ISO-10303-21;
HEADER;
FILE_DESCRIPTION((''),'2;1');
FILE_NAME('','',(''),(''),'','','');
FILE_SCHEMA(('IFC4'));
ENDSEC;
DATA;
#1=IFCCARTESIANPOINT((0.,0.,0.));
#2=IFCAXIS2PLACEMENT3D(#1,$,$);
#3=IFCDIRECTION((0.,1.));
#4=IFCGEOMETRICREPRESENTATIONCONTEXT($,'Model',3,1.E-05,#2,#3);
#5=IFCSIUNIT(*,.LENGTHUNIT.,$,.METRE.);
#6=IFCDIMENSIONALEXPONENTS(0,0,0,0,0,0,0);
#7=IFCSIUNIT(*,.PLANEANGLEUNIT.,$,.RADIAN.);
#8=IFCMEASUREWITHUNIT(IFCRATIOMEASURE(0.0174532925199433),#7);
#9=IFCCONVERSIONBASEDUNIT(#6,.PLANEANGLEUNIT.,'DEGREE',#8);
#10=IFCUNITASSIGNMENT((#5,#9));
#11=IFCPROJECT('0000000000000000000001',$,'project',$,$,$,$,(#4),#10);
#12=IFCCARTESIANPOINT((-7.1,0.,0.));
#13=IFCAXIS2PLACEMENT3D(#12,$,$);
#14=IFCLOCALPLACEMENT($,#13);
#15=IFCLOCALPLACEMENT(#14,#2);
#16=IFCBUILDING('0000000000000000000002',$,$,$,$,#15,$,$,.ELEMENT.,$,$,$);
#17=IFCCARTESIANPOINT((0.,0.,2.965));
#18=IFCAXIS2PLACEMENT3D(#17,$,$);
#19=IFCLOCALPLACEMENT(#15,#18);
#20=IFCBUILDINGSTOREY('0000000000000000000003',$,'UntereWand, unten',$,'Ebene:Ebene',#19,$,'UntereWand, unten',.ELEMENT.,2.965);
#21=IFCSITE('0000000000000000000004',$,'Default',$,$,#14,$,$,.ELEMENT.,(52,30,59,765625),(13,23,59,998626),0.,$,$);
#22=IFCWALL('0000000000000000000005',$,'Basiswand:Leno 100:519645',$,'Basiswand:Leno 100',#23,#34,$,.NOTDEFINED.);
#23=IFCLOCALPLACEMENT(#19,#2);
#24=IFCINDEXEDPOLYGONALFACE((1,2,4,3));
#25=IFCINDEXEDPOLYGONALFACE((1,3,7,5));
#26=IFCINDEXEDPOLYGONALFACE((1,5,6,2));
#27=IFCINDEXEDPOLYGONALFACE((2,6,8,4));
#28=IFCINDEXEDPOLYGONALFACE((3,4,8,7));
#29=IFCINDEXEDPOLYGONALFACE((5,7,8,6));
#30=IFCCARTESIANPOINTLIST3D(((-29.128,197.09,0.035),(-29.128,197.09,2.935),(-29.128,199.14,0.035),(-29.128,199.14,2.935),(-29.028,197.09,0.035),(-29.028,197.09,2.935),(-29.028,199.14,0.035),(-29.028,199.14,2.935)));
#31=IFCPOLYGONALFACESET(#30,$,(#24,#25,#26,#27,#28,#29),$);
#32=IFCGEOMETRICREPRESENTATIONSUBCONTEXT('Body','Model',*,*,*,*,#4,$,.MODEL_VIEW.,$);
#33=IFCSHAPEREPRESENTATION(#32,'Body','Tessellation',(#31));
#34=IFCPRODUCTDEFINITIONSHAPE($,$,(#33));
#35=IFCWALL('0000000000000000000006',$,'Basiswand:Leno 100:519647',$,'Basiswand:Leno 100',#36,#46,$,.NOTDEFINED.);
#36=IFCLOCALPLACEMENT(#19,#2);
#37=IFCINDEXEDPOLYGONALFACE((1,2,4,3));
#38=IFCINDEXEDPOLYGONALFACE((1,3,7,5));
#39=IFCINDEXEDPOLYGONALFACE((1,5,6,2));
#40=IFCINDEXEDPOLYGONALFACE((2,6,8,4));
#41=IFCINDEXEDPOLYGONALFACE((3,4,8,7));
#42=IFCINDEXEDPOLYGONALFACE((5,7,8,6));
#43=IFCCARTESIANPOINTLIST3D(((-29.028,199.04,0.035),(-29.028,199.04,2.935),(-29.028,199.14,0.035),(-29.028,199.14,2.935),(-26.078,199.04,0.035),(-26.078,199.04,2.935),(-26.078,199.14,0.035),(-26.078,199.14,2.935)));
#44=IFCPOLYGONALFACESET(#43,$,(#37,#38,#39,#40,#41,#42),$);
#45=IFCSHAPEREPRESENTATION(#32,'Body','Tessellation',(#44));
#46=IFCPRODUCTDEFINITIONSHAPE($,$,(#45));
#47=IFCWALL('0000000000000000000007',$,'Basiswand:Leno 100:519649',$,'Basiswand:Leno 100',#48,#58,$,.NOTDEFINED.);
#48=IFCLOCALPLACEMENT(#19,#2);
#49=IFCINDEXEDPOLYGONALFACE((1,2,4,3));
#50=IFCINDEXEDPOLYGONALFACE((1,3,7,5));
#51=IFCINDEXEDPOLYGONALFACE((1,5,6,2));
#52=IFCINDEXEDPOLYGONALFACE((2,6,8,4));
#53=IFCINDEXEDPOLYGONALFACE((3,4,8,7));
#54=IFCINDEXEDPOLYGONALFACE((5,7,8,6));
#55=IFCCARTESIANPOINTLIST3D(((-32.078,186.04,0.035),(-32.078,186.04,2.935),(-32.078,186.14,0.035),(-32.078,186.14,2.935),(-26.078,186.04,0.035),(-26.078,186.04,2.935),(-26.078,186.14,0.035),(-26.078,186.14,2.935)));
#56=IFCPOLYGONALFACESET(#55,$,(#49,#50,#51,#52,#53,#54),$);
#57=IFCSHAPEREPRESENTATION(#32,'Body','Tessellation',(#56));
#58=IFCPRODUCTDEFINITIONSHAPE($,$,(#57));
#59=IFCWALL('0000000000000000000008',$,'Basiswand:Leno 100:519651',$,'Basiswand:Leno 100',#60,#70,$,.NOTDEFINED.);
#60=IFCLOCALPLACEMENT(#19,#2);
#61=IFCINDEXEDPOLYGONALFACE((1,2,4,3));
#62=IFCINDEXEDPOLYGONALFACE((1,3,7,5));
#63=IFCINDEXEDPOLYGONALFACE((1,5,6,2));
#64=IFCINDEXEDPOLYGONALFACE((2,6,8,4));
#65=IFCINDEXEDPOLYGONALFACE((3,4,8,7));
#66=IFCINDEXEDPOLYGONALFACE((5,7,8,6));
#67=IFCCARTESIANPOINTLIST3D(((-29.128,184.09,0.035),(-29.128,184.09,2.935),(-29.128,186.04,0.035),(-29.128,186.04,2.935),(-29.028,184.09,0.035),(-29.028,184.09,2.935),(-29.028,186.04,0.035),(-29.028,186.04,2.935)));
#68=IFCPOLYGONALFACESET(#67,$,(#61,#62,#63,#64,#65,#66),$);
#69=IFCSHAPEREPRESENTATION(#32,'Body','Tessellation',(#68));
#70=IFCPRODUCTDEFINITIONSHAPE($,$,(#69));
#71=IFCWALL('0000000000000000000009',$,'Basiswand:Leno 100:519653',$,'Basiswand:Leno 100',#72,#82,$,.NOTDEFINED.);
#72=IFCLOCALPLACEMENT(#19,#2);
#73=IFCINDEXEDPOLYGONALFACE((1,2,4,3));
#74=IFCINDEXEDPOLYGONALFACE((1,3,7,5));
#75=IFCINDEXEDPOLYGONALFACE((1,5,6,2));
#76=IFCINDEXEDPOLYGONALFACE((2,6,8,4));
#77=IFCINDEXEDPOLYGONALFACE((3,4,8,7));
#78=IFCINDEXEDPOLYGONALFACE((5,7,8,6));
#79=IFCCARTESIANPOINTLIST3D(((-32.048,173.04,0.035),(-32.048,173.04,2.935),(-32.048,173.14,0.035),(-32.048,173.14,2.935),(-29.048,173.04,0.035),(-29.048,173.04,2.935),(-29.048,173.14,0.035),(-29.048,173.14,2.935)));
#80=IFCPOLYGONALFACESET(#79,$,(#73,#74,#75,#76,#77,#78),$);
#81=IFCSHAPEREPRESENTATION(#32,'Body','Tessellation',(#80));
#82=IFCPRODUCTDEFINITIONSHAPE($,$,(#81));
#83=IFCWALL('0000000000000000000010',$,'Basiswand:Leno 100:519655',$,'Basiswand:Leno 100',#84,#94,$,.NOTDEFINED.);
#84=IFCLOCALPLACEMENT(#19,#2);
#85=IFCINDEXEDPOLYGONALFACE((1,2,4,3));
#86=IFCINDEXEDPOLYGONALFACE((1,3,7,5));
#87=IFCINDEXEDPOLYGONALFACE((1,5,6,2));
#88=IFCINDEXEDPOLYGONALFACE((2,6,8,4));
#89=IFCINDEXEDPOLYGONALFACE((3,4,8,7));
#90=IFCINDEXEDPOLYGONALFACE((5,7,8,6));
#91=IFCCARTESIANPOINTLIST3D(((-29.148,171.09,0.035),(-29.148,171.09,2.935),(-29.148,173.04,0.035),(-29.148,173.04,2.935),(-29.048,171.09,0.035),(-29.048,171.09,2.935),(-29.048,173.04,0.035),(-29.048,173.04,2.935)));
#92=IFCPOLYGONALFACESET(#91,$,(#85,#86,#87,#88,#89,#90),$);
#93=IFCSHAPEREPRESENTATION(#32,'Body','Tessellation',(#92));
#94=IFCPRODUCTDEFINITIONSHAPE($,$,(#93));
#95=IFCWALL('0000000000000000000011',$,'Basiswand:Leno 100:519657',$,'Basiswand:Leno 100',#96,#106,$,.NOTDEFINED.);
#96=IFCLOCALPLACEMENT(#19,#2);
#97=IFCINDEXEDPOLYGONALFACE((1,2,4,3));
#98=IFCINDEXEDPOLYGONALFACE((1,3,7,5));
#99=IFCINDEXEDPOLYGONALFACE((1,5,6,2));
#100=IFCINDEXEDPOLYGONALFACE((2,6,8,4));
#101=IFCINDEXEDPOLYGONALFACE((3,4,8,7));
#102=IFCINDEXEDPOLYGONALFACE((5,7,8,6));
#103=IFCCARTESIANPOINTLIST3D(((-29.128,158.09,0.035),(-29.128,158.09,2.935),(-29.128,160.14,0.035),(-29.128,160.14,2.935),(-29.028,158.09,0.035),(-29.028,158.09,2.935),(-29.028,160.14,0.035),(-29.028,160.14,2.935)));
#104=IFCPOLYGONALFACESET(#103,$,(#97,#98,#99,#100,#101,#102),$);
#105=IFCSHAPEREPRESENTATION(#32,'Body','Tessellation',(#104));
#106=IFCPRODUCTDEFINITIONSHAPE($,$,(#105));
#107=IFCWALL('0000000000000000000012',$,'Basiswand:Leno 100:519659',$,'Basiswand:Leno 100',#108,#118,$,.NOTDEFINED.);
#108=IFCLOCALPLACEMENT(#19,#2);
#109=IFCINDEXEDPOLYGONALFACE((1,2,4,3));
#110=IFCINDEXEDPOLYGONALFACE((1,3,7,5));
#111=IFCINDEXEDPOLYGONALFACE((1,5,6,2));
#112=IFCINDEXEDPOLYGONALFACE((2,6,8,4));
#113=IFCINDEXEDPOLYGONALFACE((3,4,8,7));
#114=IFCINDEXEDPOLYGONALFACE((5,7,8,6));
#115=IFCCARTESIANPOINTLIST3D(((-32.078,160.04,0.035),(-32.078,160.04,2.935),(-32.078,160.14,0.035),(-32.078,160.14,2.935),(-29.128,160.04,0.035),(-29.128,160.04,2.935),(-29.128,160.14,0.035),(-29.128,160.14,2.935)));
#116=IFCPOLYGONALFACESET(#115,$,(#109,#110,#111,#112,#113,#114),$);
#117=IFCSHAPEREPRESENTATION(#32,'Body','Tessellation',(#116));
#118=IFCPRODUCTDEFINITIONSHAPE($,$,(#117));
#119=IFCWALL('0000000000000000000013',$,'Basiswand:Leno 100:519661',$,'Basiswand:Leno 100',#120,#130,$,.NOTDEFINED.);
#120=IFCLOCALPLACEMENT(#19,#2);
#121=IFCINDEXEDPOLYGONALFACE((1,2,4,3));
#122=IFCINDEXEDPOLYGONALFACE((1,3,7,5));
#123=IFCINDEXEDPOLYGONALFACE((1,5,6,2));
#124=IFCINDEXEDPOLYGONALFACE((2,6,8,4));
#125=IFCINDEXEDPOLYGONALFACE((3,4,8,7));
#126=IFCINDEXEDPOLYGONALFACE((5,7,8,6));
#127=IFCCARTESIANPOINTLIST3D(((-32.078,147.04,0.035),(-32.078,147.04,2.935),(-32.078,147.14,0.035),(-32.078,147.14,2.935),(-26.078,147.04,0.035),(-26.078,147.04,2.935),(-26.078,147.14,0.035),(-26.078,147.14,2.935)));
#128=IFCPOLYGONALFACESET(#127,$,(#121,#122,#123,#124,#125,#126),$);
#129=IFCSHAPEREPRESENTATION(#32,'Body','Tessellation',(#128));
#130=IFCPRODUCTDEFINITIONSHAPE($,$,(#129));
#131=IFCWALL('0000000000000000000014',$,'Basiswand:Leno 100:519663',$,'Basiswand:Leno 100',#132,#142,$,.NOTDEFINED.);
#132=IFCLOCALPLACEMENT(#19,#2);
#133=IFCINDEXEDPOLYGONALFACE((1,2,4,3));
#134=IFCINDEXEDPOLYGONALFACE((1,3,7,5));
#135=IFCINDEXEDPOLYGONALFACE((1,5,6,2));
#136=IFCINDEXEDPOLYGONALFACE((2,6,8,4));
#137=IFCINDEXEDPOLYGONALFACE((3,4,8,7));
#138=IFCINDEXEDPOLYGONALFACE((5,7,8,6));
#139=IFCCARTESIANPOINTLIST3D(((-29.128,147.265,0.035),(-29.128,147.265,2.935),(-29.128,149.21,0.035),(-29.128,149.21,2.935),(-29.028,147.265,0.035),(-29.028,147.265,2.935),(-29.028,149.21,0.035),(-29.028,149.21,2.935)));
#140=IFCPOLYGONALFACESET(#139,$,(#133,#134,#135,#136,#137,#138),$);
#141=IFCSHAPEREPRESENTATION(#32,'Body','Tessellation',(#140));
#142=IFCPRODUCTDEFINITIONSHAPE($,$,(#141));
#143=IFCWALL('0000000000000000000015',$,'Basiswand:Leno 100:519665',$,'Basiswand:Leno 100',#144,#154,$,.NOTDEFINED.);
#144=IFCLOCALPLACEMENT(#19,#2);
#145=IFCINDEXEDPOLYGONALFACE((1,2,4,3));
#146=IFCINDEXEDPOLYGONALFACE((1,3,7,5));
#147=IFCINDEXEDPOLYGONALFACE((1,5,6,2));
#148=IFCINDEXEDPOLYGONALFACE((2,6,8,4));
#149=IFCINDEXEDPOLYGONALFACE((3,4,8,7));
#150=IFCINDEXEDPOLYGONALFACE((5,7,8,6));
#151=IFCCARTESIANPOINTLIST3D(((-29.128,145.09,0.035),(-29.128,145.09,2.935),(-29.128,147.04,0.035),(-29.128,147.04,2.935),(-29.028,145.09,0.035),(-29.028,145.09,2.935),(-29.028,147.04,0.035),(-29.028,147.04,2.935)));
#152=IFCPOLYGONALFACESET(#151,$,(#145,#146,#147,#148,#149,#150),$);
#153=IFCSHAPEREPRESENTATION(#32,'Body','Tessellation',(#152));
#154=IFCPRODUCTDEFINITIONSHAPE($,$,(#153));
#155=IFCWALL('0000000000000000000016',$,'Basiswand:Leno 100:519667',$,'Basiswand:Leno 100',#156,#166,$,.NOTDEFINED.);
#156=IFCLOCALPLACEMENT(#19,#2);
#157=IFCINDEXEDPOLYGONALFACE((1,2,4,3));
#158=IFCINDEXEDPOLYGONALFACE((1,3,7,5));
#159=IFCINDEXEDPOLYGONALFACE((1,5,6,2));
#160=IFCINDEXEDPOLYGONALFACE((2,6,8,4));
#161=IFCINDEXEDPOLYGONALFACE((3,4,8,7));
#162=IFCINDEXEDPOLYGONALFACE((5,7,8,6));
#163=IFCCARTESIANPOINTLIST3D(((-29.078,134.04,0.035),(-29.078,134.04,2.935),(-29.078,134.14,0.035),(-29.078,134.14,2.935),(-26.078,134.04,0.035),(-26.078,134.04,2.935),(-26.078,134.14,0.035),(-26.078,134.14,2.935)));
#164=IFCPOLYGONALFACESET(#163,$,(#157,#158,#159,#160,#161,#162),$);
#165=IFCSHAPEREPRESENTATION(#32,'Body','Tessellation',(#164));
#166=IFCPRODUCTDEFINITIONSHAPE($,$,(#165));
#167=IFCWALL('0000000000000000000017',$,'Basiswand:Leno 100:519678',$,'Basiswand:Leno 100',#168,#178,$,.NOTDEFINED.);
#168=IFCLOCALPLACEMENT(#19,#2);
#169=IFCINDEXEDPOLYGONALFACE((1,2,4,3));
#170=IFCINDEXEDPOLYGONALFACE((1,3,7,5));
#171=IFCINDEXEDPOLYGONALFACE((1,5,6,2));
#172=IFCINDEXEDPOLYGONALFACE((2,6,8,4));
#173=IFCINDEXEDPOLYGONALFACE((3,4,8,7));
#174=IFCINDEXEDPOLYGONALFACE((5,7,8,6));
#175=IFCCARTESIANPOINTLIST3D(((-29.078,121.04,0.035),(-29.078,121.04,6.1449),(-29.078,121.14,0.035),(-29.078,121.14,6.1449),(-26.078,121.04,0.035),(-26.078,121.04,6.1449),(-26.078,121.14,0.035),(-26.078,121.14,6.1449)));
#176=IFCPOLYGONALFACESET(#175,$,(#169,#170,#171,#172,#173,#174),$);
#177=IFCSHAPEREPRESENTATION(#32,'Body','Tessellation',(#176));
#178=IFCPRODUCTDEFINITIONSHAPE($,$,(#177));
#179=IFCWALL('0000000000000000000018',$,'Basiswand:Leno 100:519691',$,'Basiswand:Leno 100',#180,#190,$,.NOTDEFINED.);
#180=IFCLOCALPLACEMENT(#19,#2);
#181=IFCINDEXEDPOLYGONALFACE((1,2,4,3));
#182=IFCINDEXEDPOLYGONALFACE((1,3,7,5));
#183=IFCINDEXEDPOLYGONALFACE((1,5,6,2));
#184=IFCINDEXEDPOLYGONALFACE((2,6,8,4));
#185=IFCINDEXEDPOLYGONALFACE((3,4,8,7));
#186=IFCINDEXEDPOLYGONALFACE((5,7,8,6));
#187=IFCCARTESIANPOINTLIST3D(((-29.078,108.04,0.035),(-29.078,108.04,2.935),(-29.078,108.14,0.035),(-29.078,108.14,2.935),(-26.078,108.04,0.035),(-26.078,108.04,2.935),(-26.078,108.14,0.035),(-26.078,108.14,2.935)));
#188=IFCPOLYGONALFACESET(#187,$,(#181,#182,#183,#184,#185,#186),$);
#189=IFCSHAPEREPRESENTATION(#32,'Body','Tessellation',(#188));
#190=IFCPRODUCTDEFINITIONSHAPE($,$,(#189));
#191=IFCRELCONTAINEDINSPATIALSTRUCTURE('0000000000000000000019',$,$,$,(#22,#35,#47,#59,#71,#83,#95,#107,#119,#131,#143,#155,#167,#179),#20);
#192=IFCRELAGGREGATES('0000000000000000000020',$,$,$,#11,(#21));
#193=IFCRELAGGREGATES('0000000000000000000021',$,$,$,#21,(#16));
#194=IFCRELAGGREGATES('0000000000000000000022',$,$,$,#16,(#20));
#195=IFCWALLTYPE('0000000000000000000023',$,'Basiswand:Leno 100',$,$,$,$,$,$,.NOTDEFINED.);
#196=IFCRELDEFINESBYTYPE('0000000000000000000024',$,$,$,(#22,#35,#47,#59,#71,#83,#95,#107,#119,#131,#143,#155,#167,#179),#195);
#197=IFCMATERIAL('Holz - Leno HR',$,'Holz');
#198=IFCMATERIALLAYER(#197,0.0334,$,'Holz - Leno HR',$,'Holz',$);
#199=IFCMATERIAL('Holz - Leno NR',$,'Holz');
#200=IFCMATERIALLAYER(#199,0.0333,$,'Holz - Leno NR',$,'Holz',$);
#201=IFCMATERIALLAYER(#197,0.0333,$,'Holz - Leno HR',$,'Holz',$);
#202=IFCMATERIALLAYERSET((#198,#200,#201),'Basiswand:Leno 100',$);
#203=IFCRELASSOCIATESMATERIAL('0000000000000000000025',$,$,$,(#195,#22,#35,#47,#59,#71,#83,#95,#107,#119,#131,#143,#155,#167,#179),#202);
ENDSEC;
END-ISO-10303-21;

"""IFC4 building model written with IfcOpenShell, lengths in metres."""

from ifc_helpers import new_model, entity, si_unit, converted_unit, direction, frame, origin, place, context, subcontext, project, spatial, indexed_curve, outline, extrude, material, layer, layer_set, type_object, element, save


model = new_model("IFC4")

# Units and contexts
model_context = context("Model", 3, precision=1e-05, world=origin(), true_north=direction((0.0, 1.0)))
body_context = subcontext(model_context, "Body", "Model", "MODEL_VIEW")
ifc_project = project(units=[si_unit("LENGTHUNIT", "METRE"), converted_unit("PLANEANGLEUNIT", "DEGREE", entity("IfcRatioMeasure", 0.0174532925199433), si_unit("PLANEANGLEUNIT", "RADIAN"), dimensions=[0, 0, 0, 0, 0, 0, 0])], contexts=[model_context])

# Site, building, storey
site_placement = place(None, frame((-7.1, 0.0, 0.0)))
site = spatial("IfcSite", under=ifc_project, at=site_placement, Name="Default", CompositionType="ELEMENT", RefLatitude=(52, 30, 59, 765625), RefLongitude=(13, 23, 59, 998626), RefElevation=0.0)
building_placement = place(site_placement, origin())
building = spatial("IfcBuilding", under=site, at=building_placement, CompositionType="ELEMENT")
storey_placement = place(building_placement, frame((0.0, 0.0, 2.965)))
storey = spatial("IfcBuildingStorey", under=building, at=storey_placement, Name="UntereWand, unten", ObjectType="Ebene:Ebene", LongName="UntereWand, unten", CompositionType="ELEMENT", Elevation=2.965)

# Walls
ifc_material_1 = material(Name="Holz - Leno HR", Category="Holz")
ifc_layer_1 = layer(ifc_material_1, 0.0334, Name="Holz - Leno HR", Category="Holz")
ifc_material_2 = material(Name="Holz - Leno NR", Category="Holz")
ifc_layer_2 = layer(ifc_material_2, 0.0333, Name="Holz - Leno NR", Category="Holz")
ifc_layer_3 = layer(ifc_material_1, 0.0333, Name="Holz - Leno HR", Category="Holz")
ifc_layer_set = layer_set([ifc_layer_1, ifc_layer_2, ifc_layer_3], Name="Basiswand:Leno 100")
wall_type = type_object("IfcWallType", Name="Basiswand:Leno 100", PredefinedType="NOTDEFINED", material=ifc_layer_set)
wall_1_placement = place(storey_placement, frame((-29.078, 197.09, 0.035), z_axis=(0.0, 0.0, 1.0), x_axis=(0.0, 1.0, 0.0)))
element("IfcWall", 1, at=wall_1_placement, inside=storey, type_object=wall_type, material=ifc_layer_set, Name="Basiswand:Leno 100:519645", ObjectType="Basiswand:Leno 100", PredefinedType="NOTDEFINED", context=body_context, shape_type="SweptSolid", body=[
    extrude(outline(indexed_curve([(2.05, 0.05), (0.0, 0.05), (0.0, -0.05), (2.05, -0.05), (2.05, 0.05)], self_intersect=False)), origin(), (0.0, 0.0, 1.0), 2.9),
])
wall_2_placement = place(storey_placement, frame((-26.078, 199.09, 0.035), z_axis=(0.0, 0.0, 1.0), x_axis=(-1.0, 0.0, 0.0)))
element("IfcWall", 2, at=wall_2_placement, inside=storey, type_object=wall_type, material=ifc_layer_set, Name="Basiswand:Leno 100:519647", ObjectType="Basiswand:Leno 100", PredefinedType="NOTDEFINED", context=body_context, shape_type="SweptSolid", body=[
    extrude(outline(indexed_curve([(2.95, 0.05), (0.0, 0.05), (0.0, -0.05), (2.95, -0.05), (2.95, 0.05)], self_intersect=False)), origin(), (0.0, 0.0, 1.0), 2.9),
])
wall_3_placement = place(storey_placement, frame((-26.078, 186.09, 0.035), z_axis=(0.0, 0.0, 1.0), x_axis=(-1.0, 0.0, 0.0)))
element("IfcWall", 3, at=wall_3_placement, inside=storey, type_object=wall_type, material=ifc_layer_set, Name="Basiswand:Leno 100:519649", ObjectType="Basiswand:Leno 100", PredefinedType="NOTDEFINED", context=body_context, shape_type="SweptSolid", body=[
    extrude(outline(indexed_curve([(6.0, 0.05), (0.0, 0.05), (0.0, -0.05), (6.0, -0.05), (6.0, 0.05)], self_intersect=False)), origin(), (0.0, 0.0, 1.0), 2.9),
])
wall_4_placement = place(storey_placement, frame((-29.078, 184.09, 0.035), z_axis=(0.0, 0.0, 1.0), x_axis=(0.0, 1.0, 0.0)))
element("IfcWall", 4, at=wall_4_placement, inside=storey, type_object=wall_type, material=ifc_layer_set, Name="Basiswand:Leno 100:519651", ObjectType="Basiswand:Leno 100", PredefinedType="NOTDEFINED", context=body_context, shape_type="SweptSolid", body=[
    extrude(outline(indexed_curve([(1.95, 0.05), (0.0, 0.05), (0.0, -0.05), (1.95, -0.05), (1.95, 0.05)], self_intersect=False)), origin(), (0.0, 0.0, 1.0), 2.9),
])
wall_5_placement = place(storey_placement, frame((-32.048, 173.09, 0.035)))
element("IfcWall", 5, at=wall_5_placement, inside=storey, type_object=wall_type, material=ifc_layer_set, Name="Basiswand:Leno 100:519653", ObjectType="Basiswand:Leno 100", PredefinedType="NOTDEFINED", context=body_context, shape_type="SweptSolid", body=[
    extrude(outline(indexed_curve([(3.0, 0.05), (0.0, 0.05), (0.0, -0.05), (3.0, -0.05), (3.0, 0.05)], self_intersect=False)), origin(), (0.0, 0.0, 1.0), 2.9),
])
wall_6_placement = place(storey_placement, frame((-29.098, 171.09, 0.035), z_axis=(0.0, 0.0, 1.0), x_axis=(0.0, 1.0, 0.0)))
element("IfcWall", 6, at=wall_6_placement, inside=storey, type_object=wall_type, material=ifc_layer_set, Name="Basiswand:Leno 100:519655", ObjectType="Basiswand:Leno 100", PredefinedType="NOTDEFINED", context=body_context, shape_type="SweptSolid", body=[
    extrude(outline(indexed_curve([(1.95, 0.05), (0.0, 0.05), (0.0, -0.05), (1.95, -0.05), (1.95, 0.05)], self_intersect=False)), origin(), (0.0, 0.0, 1.0), 2.9),
])
wall_7_placement = place(storey_placement, frame((-29.078, 158.09, 0.035), z_axis=(0.0, 0.0, 1.0), x_axis=(0.0, 1.0, 0.0)))
element("IfcWall", 7, at=wall_7_placement, inside=storey, type_object=wall_type, material=ifc_layer_set, Name="Basiswand:Leno 100:519657", ObjectType="Basiswand:Leno 100", PredefinedType="NOTDEFINED", context=body_context, shape_type="SweptSolid", body=[
    extrude(outline(indexed_curve([(2.05, 0.05), (0.0, 0.05), (0.0, -0.05), (2.05, -0.05), (2.05, 0.05)], self_intersect=False)), origin(), (0.0, 0.0, 1.0), 2.9),
])
wall_8_placement = place(storey_placement, frame((-32.078, 160.09, 0.035)))
element("IfcWall", 8, at=wall_8_placement, inside=storey, type_object=wall_type, material=ifc_layer_set, Name="Basiswand:Leno 100:519659", ObjectType="Basiswand:Leno 100", PredefinedType="NOTDEFINED", context=body_context, shape_type="SweptSolid", body=[
    extrude(outline(indexed_curve([(2.95, 0.05), (0.0, 0.05), (0.0, -0.05), (2.95, -0.05), (2.95, 0.05)], self_intersect=False)), origin(), (0.0, 0.0, 1.0), 2.9),
])
wall_9_placement = place(storey_placement, frame((-32.078, 147.09, 0.035)))
element("IfcWall", 9, at=wall_9_placement, inside=storey, type_object=wall_type, material=ifc_layer_set, Name="Basiswand:Leno 100:519661", ObjectType="Basiswand:Leno 100", PredefinedType="NOTDEFINED", context=body_context, shape_type="SweptSolid", body=[
    extrude(outline(indexed_curve([(6.0, 0.05), (0.0, 0.05), (0.0, -0.05), (6.0, -0.05), (6.0, 0.05)], self_intersect=False)), origin(), (0.0, 0.0, 1.0), 2.9),
])
wall_10_placement = place(storey_placement, frame((-29.078, 149.21, 0.035), z_axis=(0.0, 0.0, 1.0), x_axis=(0.0, -1.0, 0.0)))
element("IfcWall", 10, at=wall_10_placement, inside=storey, type_object=wall_type, material=ifc_layer_set, Name="Basiswand:Leno 100:519663", ObjectType="Basiswand:Leno 100", PredefinedType="NOTDEFINED", context=body_context, shape_type="SweptSolid", body=[
    extrude(outline(indexed_curve([(1.945, 0.05), (0.0, 0.05), (0.0, -0.05), (1.945, -0.05), (1.945, 0.05)], self_intersect=False)), origin(), (0.0, 0.0, 1.0), 2.9),
])
wall_11_placement = place(storey_placement, frame((-29.078, 145.09, 0.035), z_axis=(0.0, 0.0, 1.0), x_axis=(0.0, 1.0, 0.0)))
element("IfcWall", 11, at=wall_11_placement, inside=storey, type_object=wall_type, material=ifc_layer_set, Name="Basiswand:Leno 100:519665", ObjectType="Basiswand:Leno 100", PredefinedType="NOTDEFINED", context=body_context, shape_type="SweptSolid", body=[
    extrude(outline(indexed_curve([(1.95, 0.05), (0.0, 0.05), (0.0, -0.05), (1.95, -0.05), (1.95, 0.05)], self_intersect=False)), origin(), (0.0, 0.0, 1.0), 2.9),
])
wall_12_placement = place(storey_placement, frame((-26.078, 134.09, 0.035), z_axis=(0.0, 0.0, 1.0), x_axis=(-1.0, 0.0, 0.0)))
element("IfcWall", 12, at=wall_12_placement, inside=storey, type_object=wall_type, material=ifc_layer_set, Name="Basiswand:Leno 100:519667", ObjectType="Basiswand:Leno 100", PredefinedType="NOTDEFINED", context=body_context, shape_type="SweptSolid", body=[
    extrude(outline(indexed_curve([(3.0, 0.05), (0.0, 0.05), (0.0, -0.05), (3.0, -0.05), (3.0, 0.05)], self_intersect=False)), origin(), (0.0, 0.0, 1.0), 2.9),
])
wall_13_placement = place(storey_placement, frame((-26.078, 121.09, 0.035), z_axis=(0.0, 0.0, 1.0), x_axis=(-1.0, 0.0, 0.0)))
element("IfcWall", 13, at=wall_13_placement, inside=storey, type_object=wall_type, material=ifc_layer_set, Name="Basiswand:Leno 100:519678", ObjectType="Basiswand:Leno 100", PredefinedType="NOTDEFINED", context=body_context, shape_type="SweptSolid", body=[
    extrude(outline(indexed_curve([(3.0, 0.05), (0.0, 0.05), (0.0, -0.05), (3.0, -0.05), (3.0, 0.05)], self_intersect=False)), origin(), (0.0, 0.0, 1.0), 6.1099),
])
wall_14_placement = place(storey_placement, frame((-26.078, 108.09, 0.035), z_axis=(0.0, 0.0, 1.0), x_axis=(-1.0, 0.0, 0.0)))
element("IfcWall", 14, at=wall_14_placement, inside=storey, type_object=wall_type, material=ifc_layer_set, Name="Basiswand:Leno 100:519691", ObjectType="Basiswand:Leno 100", PredefinedType="NOTDEFINED", context=body_context, shape_type="SweptSolid", body=[
    extrude(outline(indexed_curve([(3.0, 0.05), (0.0, 0.05), (0.0, -0.05), (3.0, -0.05), (3.0, 0.05)], self_intersect=False)), origin(), (0.0, 0.0, 1.0), 2.9),
])

save(model, "model.ifc")
